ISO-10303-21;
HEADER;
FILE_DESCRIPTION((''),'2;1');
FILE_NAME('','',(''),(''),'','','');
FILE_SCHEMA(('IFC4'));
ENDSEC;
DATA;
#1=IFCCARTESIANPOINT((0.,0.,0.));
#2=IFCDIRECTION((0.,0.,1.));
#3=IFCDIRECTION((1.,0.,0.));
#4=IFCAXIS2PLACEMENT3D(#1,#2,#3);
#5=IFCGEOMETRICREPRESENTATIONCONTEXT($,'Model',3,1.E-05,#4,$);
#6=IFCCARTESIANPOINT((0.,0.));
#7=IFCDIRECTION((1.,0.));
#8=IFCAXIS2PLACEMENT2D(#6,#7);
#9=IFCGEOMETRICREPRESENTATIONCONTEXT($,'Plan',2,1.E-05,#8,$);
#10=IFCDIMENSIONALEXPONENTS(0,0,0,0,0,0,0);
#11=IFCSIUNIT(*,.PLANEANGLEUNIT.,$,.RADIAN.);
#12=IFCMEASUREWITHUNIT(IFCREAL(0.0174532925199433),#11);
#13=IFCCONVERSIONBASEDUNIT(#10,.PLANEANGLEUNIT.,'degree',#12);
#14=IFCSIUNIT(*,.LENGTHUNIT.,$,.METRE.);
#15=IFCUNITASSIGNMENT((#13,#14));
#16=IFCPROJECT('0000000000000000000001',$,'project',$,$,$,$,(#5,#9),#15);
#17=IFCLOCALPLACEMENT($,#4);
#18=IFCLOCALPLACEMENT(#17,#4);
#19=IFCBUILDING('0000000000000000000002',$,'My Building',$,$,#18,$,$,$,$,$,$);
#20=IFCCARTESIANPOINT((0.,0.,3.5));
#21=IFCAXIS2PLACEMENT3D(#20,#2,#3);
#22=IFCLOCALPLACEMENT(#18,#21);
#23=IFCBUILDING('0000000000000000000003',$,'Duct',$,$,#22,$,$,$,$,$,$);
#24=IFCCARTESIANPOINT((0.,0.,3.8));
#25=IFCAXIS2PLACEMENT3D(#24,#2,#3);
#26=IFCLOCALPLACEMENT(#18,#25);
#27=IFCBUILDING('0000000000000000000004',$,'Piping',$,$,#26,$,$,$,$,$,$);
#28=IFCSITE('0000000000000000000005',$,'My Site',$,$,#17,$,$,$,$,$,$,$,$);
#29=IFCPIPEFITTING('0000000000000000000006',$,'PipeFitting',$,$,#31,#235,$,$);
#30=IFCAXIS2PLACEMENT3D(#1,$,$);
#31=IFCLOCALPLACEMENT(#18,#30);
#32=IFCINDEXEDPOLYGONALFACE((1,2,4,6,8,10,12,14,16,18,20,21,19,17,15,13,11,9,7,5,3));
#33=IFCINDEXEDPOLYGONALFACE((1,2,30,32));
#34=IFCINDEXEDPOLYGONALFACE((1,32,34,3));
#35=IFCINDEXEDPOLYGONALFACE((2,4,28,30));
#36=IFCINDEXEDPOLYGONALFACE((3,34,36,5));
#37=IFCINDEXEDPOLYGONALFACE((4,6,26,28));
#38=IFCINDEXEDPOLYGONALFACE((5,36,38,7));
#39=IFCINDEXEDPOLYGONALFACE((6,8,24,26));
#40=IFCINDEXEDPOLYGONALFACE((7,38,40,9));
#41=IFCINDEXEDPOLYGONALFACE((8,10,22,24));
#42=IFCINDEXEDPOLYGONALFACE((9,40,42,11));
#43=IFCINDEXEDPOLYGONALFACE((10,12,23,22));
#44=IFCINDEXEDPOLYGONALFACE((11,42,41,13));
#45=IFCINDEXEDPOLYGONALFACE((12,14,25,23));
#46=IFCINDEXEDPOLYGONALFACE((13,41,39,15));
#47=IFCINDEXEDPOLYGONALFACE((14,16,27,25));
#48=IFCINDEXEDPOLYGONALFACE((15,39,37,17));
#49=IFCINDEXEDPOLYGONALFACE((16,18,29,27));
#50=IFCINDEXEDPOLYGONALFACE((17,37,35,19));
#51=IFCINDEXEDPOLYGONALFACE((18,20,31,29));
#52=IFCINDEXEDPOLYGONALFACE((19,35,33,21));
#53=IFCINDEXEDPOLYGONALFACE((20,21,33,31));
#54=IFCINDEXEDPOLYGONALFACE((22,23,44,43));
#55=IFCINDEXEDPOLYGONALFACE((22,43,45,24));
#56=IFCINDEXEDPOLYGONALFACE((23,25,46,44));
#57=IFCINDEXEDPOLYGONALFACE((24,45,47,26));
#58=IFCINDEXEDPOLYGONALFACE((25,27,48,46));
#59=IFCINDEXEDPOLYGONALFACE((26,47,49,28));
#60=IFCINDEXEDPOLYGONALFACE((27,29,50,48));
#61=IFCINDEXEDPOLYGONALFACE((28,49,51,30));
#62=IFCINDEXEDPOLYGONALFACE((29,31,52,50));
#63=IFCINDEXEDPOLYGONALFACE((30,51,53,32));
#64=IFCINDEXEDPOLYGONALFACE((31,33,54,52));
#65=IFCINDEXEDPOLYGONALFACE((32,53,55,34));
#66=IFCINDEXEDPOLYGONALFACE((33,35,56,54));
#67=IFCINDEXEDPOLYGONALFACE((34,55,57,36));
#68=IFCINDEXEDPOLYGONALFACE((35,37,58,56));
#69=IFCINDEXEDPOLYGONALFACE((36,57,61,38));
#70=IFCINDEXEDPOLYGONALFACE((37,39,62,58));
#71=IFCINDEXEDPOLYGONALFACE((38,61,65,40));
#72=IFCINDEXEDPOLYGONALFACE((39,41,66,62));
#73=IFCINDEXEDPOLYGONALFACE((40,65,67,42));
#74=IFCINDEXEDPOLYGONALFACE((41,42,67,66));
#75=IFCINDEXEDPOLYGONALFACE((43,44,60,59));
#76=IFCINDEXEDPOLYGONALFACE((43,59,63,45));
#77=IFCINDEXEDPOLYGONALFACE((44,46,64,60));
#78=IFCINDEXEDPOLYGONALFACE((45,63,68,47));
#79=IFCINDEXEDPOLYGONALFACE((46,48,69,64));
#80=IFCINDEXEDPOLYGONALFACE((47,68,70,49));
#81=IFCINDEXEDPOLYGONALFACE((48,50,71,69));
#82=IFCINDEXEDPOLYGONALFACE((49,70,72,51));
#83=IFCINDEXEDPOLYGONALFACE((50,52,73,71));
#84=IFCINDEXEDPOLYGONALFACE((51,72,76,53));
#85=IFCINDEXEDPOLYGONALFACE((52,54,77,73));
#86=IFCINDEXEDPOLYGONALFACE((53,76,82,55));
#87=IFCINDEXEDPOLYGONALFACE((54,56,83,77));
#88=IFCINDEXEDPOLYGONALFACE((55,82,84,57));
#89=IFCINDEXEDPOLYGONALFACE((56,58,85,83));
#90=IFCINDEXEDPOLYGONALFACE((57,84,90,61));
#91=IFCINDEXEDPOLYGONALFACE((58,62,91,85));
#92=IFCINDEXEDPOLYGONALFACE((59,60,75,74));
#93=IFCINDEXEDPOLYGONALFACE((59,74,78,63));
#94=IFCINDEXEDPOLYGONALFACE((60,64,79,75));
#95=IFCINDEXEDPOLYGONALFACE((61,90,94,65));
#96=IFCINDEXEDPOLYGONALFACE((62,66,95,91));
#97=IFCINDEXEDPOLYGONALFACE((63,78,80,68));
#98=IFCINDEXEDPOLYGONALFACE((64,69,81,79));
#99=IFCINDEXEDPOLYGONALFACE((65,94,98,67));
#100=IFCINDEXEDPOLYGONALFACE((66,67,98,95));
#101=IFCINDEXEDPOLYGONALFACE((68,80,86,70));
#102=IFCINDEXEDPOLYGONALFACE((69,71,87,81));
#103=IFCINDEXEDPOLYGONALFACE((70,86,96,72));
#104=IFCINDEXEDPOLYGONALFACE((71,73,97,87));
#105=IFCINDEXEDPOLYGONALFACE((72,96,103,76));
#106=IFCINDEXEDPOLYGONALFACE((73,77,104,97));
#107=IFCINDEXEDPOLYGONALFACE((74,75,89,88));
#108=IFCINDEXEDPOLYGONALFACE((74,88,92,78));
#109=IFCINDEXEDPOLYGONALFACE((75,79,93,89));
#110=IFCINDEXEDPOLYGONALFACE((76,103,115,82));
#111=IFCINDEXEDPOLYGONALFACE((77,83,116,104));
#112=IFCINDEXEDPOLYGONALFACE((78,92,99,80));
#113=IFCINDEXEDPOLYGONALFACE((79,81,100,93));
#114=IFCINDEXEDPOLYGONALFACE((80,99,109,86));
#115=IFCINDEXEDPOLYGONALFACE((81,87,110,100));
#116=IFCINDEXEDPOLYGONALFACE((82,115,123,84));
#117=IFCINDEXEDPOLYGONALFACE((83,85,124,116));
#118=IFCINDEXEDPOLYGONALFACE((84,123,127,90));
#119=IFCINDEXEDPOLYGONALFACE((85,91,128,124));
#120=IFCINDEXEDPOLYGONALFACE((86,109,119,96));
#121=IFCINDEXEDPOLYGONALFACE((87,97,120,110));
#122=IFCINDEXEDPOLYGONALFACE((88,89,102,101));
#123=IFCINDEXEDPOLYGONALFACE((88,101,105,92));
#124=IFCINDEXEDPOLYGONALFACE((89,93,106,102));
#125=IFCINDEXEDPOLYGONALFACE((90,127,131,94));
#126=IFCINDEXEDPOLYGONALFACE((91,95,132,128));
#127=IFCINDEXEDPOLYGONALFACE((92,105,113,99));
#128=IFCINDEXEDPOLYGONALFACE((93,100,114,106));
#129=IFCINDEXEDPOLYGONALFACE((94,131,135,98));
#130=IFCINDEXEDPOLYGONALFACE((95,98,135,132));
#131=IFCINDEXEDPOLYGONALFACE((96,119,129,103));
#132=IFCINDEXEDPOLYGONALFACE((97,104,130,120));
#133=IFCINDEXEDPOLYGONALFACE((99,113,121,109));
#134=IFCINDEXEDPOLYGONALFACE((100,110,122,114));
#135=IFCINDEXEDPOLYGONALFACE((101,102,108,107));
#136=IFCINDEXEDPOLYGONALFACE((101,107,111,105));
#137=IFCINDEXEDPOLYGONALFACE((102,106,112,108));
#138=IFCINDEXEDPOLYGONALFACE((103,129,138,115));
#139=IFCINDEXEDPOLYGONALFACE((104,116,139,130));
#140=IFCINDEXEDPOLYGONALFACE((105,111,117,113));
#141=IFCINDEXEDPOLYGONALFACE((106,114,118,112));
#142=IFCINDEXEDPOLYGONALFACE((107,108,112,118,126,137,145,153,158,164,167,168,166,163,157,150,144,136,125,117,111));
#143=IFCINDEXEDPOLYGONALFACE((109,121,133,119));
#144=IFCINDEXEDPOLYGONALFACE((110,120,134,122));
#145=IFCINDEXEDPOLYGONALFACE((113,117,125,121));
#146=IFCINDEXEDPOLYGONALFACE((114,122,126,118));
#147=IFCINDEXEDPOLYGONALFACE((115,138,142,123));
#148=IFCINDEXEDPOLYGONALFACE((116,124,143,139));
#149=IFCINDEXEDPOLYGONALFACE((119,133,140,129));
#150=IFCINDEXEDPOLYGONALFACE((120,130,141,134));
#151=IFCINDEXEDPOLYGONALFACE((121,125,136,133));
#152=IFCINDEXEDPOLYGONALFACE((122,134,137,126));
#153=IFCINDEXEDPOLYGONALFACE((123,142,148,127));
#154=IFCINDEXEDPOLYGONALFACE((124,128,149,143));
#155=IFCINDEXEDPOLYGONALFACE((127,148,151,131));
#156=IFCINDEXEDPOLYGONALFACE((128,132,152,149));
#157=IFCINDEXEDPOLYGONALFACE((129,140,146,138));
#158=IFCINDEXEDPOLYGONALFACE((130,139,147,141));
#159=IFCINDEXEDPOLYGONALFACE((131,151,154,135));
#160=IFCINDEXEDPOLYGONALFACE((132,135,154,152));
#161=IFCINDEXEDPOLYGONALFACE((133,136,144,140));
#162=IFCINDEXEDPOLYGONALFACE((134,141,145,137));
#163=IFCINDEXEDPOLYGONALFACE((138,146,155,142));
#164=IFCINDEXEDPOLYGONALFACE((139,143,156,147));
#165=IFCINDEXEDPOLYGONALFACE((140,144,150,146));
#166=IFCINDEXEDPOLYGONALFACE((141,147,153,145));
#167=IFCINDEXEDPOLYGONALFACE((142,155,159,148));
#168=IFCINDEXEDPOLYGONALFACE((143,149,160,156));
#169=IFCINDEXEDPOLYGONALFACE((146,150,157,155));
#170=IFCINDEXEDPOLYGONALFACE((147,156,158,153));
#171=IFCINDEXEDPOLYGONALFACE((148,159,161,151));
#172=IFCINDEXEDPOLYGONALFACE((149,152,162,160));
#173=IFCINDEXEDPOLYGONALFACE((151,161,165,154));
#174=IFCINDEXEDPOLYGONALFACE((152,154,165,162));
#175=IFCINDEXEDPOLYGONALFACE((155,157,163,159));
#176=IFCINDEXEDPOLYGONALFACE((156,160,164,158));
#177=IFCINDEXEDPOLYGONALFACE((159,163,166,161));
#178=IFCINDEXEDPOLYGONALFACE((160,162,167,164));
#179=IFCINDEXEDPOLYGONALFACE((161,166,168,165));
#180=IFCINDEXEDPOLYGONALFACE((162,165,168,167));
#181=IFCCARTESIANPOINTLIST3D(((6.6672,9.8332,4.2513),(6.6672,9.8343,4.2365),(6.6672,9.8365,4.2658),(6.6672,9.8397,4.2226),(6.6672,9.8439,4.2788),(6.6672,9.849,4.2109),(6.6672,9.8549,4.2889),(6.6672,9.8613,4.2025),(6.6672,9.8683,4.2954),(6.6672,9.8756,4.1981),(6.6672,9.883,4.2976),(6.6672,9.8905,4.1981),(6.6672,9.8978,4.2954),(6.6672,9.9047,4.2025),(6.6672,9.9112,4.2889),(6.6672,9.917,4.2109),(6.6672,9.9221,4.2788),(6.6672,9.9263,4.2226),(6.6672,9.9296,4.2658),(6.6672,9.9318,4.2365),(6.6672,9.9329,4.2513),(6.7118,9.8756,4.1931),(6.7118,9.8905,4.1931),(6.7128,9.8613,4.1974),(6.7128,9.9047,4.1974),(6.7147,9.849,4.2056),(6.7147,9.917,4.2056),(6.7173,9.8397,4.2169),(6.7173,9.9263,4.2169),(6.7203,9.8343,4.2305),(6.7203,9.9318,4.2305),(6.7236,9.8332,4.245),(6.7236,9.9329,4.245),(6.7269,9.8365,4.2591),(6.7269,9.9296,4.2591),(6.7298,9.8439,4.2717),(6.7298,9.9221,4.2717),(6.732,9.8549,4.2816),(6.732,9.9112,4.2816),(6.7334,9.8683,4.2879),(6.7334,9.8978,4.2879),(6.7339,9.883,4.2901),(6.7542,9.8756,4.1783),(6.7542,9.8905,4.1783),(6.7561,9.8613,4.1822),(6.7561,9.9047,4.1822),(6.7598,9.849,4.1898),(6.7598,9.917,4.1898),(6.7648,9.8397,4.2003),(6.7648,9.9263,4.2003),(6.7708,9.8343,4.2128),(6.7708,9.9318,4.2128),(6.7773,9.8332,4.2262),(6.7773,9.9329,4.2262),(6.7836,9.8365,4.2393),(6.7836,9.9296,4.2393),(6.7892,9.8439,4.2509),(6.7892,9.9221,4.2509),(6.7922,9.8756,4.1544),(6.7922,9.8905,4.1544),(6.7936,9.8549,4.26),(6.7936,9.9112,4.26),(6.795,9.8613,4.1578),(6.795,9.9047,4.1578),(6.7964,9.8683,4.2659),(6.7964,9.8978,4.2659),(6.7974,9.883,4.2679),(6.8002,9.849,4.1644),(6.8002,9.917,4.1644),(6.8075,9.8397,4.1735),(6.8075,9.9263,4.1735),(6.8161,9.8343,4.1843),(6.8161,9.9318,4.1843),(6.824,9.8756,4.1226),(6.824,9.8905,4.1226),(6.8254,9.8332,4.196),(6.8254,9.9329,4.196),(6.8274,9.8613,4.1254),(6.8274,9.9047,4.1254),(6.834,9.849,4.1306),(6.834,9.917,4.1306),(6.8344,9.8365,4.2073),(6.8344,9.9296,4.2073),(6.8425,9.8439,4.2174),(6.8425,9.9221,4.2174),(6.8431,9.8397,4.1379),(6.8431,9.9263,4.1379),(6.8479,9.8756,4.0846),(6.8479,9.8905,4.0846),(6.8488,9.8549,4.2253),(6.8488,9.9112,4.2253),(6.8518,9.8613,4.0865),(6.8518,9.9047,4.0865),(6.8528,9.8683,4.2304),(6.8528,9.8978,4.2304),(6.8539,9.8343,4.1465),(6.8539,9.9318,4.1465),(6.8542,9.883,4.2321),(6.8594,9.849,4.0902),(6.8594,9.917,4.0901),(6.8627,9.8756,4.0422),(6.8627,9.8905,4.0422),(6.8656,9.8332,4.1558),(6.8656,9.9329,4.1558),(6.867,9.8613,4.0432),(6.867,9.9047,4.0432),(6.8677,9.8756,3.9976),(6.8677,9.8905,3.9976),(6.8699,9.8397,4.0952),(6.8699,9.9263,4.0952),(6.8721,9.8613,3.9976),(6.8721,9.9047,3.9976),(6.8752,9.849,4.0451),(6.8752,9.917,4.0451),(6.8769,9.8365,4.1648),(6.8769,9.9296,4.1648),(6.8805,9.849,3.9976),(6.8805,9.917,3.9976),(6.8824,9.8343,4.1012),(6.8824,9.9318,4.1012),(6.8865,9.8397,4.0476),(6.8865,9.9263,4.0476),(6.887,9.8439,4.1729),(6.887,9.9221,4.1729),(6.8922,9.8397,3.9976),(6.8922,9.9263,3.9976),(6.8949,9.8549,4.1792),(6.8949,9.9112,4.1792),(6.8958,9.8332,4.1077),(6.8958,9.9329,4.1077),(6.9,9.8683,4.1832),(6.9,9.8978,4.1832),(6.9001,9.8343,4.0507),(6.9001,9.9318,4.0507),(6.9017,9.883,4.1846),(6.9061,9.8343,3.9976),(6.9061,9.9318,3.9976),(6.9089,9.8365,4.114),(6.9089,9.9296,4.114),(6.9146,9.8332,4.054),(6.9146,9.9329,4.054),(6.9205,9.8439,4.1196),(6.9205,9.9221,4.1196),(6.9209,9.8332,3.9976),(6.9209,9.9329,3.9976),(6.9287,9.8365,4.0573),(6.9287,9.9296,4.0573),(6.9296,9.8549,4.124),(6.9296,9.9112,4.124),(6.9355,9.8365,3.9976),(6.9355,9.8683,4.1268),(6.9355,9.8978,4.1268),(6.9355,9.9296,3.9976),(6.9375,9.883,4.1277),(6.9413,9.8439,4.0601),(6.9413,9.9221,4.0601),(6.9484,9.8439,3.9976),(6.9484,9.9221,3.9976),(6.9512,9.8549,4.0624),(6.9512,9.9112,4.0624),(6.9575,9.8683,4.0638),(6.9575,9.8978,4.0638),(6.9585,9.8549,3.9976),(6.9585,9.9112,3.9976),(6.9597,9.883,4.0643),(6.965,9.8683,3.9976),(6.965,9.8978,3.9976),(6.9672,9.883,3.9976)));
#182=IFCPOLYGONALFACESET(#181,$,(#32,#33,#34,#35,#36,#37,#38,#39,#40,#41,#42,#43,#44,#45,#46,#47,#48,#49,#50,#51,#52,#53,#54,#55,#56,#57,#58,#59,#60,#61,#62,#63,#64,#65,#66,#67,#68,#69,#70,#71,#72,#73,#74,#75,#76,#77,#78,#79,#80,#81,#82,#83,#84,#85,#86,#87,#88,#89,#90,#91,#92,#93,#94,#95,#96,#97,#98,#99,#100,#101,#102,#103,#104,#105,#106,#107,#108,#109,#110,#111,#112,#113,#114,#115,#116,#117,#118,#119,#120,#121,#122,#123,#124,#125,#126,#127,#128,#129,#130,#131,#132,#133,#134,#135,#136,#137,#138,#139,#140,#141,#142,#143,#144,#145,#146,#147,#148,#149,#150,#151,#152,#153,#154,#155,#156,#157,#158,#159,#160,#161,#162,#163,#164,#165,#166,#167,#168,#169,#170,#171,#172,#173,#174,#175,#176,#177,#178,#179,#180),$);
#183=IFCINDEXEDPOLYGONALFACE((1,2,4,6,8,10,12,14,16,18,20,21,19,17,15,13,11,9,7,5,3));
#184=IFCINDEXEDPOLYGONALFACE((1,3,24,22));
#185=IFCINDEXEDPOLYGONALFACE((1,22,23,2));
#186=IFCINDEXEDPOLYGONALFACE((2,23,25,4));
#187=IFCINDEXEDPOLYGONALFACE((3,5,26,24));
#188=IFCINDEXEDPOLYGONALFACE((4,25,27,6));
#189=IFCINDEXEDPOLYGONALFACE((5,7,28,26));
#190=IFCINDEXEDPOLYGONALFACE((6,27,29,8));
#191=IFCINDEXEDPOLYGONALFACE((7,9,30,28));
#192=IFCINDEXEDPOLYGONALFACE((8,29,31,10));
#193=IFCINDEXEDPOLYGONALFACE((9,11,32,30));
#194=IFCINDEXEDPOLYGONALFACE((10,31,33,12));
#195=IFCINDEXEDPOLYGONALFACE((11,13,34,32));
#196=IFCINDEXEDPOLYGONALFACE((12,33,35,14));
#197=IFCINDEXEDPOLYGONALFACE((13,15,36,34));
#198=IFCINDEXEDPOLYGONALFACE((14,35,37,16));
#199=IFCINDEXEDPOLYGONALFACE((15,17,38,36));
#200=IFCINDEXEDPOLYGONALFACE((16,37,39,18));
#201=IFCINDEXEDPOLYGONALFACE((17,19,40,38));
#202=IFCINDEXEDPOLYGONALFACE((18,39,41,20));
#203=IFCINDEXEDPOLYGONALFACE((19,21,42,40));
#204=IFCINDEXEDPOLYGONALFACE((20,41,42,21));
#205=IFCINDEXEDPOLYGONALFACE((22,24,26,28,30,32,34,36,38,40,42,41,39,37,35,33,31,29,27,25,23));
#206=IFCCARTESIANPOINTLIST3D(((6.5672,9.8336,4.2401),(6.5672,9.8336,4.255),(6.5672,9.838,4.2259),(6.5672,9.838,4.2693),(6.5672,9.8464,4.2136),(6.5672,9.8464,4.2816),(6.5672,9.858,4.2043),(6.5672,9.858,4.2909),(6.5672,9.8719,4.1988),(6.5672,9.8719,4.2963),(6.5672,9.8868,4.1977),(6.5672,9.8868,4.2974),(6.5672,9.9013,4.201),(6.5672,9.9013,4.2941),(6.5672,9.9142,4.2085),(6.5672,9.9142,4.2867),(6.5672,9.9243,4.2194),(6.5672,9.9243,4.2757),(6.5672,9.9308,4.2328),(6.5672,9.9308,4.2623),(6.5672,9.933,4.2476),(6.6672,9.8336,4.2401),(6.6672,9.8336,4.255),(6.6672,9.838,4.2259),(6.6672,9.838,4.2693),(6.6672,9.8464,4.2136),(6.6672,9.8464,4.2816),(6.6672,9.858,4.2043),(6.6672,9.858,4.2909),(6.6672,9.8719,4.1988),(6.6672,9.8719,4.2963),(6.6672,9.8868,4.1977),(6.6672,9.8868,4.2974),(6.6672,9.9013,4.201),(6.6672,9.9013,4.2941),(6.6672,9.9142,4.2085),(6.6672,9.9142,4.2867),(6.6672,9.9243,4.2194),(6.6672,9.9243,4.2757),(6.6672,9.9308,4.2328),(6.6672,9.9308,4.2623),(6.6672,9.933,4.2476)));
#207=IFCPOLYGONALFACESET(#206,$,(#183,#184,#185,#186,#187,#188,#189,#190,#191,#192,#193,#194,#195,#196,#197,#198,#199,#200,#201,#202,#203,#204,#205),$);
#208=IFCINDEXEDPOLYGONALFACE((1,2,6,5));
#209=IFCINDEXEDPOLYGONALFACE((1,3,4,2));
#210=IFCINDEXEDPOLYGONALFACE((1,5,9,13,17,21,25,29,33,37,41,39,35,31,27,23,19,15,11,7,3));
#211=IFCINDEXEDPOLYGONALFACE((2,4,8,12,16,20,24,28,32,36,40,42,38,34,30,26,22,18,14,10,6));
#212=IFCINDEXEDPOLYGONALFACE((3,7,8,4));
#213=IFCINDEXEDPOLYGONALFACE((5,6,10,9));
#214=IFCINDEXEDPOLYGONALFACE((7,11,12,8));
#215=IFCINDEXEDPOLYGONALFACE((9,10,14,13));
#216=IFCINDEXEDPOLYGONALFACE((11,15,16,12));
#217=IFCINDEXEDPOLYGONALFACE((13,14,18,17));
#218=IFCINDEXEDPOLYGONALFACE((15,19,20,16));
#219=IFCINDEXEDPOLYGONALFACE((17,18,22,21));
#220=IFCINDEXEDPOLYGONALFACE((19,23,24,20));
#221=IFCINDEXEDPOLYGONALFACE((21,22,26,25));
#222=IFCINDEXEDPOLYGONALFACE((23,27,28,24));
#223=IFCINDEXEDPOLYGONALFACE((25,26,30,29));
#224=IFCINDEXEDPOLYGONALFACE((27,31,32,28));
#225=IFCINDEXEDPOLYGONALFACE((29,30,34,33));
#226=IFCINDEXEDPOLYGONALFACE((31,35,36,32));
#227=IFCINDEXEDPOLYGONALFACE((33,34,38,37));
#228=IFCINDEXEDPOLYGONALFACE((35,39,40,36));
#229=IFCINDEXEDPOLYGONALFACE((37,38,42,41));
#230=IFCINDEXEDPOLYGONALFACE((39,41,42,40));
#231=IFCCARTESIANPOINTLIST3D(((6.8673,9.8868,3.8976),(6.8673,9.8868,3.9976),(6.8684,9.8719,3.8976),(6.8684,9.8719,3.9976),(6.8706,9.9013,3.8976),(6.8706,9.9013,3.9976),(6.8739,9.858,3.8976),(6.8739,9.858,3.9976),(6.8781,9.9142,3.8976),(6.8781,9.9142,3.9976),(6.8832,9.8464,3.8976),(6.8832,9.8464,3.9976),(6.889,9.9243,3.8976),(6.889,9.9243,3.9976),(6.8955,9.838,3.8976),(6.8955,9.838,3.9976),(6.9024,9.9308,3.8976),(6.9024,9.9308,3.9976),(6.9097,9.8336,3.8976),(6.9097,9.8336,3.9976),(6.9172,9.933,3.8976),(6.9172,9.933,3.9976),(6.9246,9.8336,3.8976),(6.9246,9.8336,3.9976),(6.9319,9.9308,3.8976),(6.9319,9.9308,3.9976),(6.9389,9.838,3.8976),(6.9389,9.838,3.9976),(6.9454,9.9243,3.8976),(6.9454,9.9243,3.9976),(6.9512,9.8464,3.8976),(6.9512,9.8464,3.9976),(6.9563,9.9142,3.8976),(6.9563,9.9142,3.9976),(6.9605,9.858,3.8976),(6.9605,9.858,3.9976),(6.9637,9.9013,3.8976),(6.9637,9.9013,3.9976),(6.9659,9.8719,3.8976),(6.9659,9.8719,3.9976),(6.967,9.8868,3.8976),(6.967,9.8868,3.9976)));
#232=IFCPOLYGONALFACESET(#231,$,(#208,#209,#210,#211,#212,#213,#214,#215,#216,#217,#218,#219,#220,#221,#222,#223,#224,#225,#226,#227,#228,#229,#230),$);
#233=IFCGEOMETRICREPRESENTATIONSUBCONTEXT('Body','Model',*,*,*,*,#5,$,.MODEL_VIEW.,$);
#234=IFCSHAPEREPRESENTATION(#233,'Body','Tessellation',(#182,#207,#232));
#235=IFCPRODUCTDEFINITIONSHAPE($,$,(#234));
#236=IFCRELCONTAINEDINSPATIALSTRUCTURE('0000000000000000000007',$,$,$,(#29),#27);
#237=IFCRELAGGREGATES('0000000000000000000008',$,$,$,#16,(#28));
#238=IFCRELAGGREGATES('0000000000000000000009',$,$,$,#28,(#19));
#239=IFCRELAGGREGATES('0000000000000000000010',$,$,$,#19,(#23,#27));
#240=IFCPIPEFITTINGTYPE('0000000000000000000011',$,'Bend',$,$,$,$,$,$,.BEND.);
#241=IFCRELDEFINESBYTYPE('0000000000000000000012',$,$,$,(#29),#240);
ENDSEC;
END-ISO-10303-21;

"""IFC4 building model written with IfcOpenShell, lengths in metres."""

from ifc_helpers import new_model, entity, si_unit, converted_unit, frame, origin_with_axes, origin_2d_with_axis, place, context, subcontext, project, spatial, circle, extrude, source, transform, mapped, type_object, type_shapes, element, save


model = new_model("IFC4")

# Units and contexts
model_context = context("Model", 3, precision=1e-05, world=origin_with_axes())
plan_context = context("Plan", 2, precision=1e-05, world=origin_2d_with_axis())
body_context = subcontext(model_context, "Body", "Model", "MODEL_VIEW")
ifc_project = project(units=[converted_unit("PLANEANGLEUNIT", "degree", entity("IfcReal", 0.0174532925199433), si_unit("PLANEANGLEUNIT", "RADIAN"), dimensions=[0, 0, 0, 0, 0, 0, 0]), si_unit("LENGTHUNIT", "METRE")], contexts=[model_context, plan_context])

# Site, building
site_placement = place(None, origin_with_axes())
site = spatial("IfcSite", under=ifc_project, at=site_placement, Name="My Site")
building_1_placement = place(site_placement, origin_with_axes())
building_1 = spatial("IfcBuilding", under=site, at=building_1_placement, Name="My Building")

# Shared definitions
building_2_placement = place(building_1_placement, frame((0.0, 0.0, 3.5), z_axis=(0.0, 0.0, 1.0), x_axis=(1.0, 0.0, 0.0)))
building_2 = spatial("IfcBuilding", under=building_1, at=building_2_placement, Name="Duct")

# Shared definitions
building_3_placement = place(building_1_placement, frame((0.0, 0.0, 3.8), z_axis=(0.0, 0.0, 1.0), x_axis=(1.0, 0.0, 0.0)))
building_3 = spatial("IfcBuilding", under=building_1, at=building_3_placement, Name="Piping")

# Pipe fitting
pipe_fitting_type_1 = type_object("IfcPipeFittingType", Name="Bend", PredefinedType="BEND")
shared_shape = source(origin_with_axes(), body_context, "Body", "SolidModel", [
    entity("IfcSweptDiskSolid", entity("IfcIndexedPolyCurve", entity("IfcCartesianPointList3D", [[0.0, 0.0, 0.1], [0.0, -0.0732, 0.2768], [0.0, -0.25, 0.35]]), [entity("IfcArcIndex", [1, 2, 3])]), 0.05),
    extrude(circle(Radius=0.05), origin_with_axes(), (0.0, 0.0, 1.0), 0.1),
    extrude(circle(Radius=0.05), frame((0.0, -0.25, 0.35), z_axis=(0.0, -1.0, -0.000001), x_axis=(1.0, 0.0, 0.0)), (0.0, 0.0, 1.0), 0.1),
])
type_shapes(pipe_fitting_type_1, [shared_shape])
for number, where, z_axis, x_axis, name in (
    (1, (6.5672, 9.883, 0.4476), (1.0, -0.000001, 0.000001), (0.000001, 1.0, 0.0), "PipeFitting"),
):
    element("IfcPipeFitting", number, at=place(building_3_placement, frame(where, z_axis=z_axis, x_axis=x_axis)), inside=building_3, type_object=pipe_fitting_type_1, Name=name, context=body_context, shape_type="MappedRepresentation", body=[
        mapped(shared_shape, transform((0.0, 0.0, 0.0), x_axis=(1.0, 0.0, 0.0), y_axis=(0.0, 1.0, 0.0), z_axis=(0.0, 0.0, 1.0), scale=1.0)),
    ])

save(model, "model.ifc")
